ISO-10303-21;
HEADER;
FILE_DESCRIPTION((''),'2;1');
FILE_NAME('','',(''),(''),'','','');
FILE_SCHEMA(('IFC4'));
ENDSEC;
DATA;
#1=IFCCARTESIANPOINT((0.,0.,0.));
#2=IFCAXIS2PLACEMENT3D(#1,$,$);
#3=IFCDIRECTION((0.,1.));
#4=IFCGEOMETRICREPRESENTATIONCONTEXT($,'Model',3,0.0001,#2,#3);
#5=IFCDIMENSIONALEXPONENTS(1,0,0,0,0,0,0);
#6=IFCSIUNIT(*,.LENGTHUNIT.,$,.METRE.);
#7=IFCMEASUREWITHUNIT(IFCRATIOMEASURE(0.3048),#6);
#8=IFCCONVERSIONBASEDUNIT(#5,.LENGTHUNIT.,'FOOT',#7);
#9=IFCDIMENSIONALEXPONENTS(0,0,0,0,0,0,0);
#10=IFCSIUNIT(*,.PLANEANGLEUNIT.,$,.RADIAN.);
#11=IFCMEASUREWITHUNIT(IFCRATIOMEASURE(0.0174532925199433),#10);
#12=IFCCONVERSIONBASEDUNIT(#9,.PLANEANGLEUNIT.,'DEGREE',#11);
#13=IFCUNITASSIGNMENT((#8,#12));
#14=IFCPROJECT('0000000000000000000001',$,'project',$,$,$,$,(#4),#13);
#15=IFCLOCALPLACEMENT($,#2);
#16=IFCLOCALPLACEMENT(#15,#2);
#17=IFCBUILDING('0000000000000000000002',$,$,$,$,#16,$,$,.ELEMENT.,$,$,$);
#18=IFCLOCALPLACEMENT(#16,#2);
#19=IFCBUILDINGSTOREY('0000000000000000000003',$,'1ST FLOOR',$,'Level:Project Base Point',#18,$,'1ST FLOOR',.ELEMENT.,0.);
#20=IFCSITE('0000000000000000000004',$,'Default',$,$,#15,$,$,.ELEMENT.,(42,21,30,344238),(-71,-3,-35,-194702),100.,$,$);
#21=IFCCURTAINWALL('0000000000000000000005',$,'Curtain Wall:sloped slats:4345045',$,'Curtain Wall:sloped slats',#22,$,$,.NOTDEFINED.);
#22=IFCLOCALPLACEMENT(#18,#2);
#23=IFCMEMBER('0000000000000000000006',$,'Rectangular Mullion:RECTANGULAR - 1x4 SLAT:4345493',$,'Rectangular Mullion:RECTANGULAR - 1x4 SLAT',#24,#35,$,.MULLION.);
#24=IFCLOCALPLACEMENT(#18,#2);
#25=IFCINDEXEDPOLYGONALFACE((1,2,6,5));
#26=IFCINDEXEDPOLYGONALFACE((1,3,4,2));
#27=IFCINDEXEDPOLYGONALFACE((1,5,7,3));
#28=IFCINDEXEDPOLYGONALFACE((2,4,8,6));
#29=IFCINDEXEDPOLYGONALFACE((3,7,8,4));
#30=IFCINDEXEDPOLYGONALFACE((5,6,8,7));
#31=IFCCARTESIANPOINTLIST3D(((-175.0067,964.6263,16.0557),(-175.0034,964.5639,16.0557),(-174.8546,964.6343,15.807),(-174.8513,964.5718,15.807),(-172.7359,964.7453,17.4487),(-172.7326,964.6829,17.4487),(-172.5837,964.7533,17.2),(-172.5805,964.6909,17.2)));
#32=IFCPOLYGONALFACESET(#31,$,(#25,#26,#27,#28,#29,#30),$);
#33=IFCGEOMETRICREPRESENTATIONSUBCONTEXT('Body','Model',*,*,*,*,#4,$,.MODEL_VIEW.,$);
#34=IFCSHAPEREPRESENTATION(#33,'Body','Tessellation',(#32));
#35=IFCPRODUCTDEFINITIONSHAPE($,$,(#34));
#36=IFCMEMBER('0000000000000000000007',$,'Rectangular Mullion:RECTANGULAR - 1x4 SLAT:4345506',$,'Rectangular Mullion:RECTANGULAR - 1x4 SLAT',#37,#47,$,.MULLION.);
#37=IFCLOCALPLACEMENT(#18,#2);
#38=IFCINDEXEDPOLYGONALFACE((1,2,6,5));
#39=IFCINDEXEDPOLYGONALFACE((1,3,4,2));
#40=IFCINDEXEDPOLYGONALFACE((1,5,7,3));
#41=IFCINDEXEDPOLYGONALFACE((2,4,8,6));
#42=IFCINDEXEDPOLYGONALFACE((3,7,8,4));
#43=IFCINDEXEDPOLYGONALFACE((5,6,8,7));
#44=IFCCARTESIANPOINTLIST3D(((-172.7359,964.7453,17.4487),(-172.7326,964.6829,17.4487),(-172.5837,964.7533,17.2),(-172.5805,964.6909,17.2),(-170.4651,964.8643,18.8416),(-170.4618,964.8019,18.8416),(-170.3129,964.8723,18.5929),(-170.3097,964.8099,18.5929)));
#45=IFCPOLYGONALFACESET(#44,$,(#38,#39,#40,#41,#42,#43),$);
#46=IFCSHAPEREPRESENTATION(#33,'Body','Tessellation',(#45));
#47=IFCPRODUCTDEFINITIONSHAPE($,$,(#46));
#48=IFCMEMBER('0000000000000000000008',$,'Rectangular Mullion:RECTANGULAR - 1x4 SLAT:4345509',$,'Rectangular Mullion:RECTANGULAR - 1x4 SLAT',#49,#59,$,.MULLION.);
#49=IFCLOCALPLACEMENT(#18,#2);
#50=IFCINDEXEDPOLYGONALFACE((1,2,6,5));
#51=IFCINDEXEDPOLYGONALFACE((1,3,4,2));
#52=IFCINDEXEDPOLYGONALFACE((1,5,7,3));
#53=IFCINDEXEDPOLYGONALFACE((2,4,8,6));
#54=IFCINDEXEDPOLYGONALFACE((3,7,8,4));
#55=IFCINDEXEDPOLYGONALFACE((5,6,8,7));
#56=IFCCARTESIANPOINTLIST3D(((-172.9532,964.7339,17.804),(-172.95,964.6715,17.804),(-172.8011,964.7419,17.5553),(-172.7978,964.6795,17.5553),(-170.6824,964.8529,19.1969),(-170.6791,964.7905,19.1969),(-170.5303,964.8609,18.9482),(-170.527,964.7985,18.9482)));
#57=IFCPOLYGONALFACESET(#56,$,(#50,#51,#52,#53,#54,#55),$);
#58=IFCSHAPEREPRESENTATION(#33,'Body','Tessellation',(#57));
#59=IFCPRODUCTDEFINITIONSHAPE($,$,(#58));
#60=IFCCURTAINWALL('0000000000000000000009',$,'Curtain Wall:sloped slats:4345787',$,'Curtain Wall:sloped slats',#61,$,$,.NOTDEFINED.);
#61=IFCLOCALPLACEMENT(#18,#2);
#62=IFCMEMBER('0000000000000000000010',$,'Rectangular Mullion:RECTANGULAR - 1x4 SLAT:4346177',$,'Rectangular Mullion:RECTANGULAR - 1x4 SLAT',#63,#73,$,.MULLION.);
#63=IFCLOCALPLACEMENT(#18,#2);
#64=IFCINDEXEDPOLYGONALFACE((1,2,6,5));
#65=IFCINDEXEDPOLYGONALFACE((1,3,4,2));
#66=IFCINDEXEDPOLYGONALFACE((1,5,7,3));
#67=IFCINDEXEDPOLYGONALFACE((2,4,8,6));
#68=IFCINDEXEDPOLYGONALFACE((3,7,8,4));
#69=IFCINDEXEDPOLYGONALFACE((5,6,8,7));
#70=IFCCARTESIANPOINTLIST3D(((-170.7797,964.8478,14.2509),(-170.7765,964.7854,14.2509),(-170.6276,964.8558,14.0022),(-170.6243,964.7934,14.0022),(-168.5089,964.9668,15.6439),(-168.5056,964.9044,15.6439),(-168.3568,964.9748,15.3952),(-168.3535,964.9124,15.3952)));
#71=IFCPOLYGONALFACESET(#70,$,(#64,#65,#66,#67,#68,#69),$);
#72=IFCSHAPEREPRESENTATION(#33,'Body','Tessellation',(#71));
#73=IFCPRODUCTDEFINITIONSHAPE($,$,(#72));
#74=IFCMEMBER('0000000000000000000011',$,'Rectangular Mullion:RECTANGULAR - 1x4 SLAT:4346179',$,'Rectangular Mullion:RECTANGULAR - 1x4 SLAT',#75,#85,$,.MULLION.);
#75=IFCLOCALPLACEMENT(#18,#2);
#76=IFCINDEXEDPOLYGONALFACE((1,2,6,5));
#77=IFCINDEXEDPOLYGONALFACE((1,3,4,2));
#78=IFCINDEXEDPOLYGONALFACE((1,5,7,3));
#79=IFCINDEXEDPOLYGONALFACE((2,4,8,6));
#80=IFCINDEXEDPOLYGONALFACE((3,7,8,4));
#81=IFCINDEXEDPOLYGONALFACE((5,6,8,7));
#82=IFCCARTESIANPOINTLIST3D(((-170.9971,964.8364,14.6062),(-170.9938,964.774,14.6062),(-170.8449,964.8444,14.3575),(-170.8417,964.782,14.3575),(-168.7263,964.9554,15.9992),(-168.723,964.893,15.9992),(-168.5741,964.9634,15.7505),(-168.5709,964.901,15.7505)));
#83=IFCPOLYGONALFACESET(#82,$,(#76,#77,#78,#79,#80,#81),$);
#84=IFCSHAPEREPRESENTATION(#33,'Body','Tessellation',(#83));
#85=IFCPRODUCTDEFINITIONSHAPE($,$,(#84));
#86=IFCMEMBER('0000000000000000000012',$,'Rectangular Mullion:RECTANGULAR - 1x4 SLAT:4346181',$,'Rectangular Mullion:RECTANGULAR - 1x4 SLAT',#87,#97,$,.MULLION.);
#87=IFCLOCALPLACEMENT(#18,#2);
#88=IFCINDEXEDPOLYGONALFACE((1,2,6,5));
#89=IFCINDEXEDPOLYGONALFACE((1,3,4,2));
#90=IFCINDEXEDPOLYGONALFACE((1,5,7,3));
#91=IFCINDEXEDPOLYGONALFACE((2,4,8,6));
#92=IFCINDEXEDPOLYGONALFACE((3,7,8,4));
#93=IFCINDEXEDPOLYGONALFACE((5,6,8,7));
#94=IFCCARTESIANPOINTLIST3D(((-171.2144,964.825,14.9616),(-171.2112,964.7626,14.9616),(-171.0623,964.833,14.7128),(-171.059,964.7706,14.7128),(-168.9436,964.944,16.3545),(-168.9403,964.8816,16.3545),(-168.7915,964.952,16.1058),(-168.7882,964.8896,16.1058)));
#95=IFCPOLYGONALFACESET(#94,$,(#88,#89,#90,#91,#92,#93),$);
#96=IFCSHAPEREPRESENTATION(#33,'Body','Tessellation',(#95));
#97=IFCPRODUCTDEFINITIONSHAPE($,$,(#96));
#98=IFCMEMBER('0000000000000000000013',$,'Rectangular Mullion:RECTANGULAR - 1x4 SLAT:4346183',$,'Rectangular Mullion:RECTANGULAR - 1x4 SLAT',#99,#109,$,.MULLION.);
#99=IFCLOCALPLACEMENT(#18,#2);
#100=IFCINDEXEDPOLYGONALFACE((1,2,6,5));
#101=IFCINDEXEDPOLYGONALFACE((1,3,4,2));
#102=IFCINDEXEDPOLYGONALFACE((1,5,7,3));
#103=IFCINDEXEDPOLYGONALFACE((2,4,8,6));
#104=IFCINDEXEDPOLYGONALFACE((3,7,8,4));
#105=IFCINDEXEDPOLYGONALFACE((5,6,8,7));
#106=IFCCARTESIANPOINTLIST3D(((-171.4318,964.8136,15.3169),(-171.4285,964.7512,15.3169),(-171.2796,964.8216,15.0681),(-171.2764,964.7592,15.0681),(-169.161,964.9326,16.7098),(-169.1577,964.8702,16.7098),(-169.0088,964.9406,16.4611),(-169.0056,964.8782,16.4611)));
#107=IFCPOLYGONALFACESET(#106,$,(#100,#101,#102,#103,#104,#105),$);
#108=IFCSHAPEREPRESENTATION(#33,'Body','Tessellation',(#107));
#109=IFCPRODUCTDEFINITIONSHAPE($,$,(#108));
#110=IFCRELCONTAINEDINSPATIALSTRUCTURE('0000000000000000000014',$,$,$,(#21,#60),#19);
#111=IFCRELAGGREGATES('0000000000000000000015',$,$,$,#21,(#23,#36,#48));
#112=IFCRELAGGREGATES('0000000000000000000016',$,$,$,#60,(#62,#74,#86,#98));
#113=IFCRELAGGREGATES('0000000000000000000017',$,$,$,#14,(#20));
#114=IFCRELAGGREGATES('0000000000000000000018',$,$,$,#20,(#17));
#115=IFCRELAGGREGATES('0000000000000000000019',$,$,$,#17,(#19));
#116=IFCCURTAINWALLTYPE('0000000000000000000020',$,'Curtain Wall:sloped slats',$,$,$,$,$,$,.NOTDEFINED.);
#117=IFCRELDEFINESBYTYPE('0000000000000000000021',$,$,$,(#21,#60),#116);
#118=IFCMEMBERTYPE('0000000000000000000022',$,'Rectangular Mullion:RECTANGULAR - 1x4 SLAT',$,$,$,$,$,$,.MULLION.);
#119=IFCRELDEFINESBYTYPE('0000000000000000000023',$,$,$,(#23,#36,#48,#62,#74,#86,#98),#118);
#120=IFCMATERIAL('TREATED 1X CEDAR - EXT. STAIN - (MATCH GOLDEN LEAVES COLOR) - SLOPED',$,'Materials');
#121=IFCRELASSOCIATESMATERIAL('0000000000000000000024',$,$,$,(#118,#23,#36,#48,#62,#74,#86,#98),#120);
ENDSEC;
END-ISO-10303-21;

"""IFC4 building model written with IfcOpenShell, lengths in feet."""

from ifc_helpers import new_model, entity, si_unit, converted_unit, direction, frame, frame_2d, origin, place, context, subcontext, project, spatial, rectangle, extrude, source, transform, mapped, material, material_profile, profile_set, profile_usage, type_object, type_shapes, element, aggregate, save


model = new_model("IFC4")

# Units and contexts
model_context = context("Model", 3, precision=0.0001, world=origin(), true_north=direction((0.0, 1.0)))
body_context = subcontext(model_context, "Body", "Model", "MODEL_VIEW")
ifc_project = project(units=[converted_unit("LENGTHUNIT", "FOOT", entity("IfcRatioMeasure", 0.3048), si_unit("LENGTHUNIT", "METRE"), dimensions=[1, 0, 0, 0, 0, 0, 0]), converted_unit("PLANEANGLEUNIT", "DEGREE", entity("IfcRatioMeasure", 0.0174532925199433), si_unit("PLANEANGLEUNIT", "RADIAN"), dimensions=[0, 0, 0, 0, 0, 0, 0])], contexts=[model_context])

# Site, building, storey
site_placement = place(None, origin())
site = spatial("IfcSite", under=ifc_project, at=site_placement, Name="Default", CompositionType="ELEMENT", RefLatitude=(42, 21, 30, 344238), RefLongitude=(-71, -3, -35, -194702), RefElevation=100.0)
building_placement = place(site_placement, origin())
building = spatial("IfcBuilding", under=site, at=building_placement, CompositionType="ELEMENT")
storey_placement = place(building_placement, origin())
storey = spatial("IfcBuildingStorey", under=building, at=storey_placement, Name="1ST FLOOR", ObjectType="Level:Project Base Point", LongName="1ST FLOOR", CompositionType="ELEMENT", Elevation=0.0)

# Curtain walls, members
curtain_wall_type_1 = type_object("IfcCurtainWallType", Name="Curtain Wall:sloped slats", PredefinedType="NOTDEFINED")
curtain_wall_1_placement = place(storey_placement, origin())
curtain_wall_1 = element("IfcCurtainWall", 1, at=curtain_wall_1_placement, inside=storey, type_object=curtain_wall_type_1, Name="Curtain Wall:sloped slats:4345045", ObjectType="Curtain Wall:sloped slats", PredefinedType="NOTDEFINED")
ifc_material_1 = material(Name="TREATED 1X CEDAR - EXT. STAIN - (MATCH GOLDEN LEAVES COLOR) - SLOPED", Category="Materials")
ifc_material_profile_1 = material_profile(ifc_material_1, rectangle(XDim=0.0625, YDim=0.2917, at=frame_2d((0.0, 0.0), x_axis=(1.0, 0.0))), Name="RECTANGULAR - 1x4 SLAT")
ifc_profile_set_1 = profile_set([ifc_material_profile_1], Name="RECTANGULAR - 1x4 SLAT")
ifc_profile_usage_1 = profile_usage(ifc_profile_set_1)
member_type_1 = type_object("IfcMemberType", Name="Rectangular Mullion:RECTANGULAR - 1x4 SLAT", PredefinedType="MULLION", material=ifc_profile_set_1)
shared_shape_1 = source(origin(), body_context, "Body", "SweptSolid", [
    extrude(rectangle(XDim=0.0625, YDim=0.2917, at=frame_2d((0.0, 0.0), x_axis=(1.0, 0.0))), frame((0.0, 0.0, -2.6667), z_axis=(0.0, 0.0, 1.0), x_axis=(0.0, -1.0, 0.0)), (0.0, 0.0, 1.0), 2.6667),
])
type_shapes(member_type_1, [shared_shape_1])
member_1_placement = place(storey_placement, frame((-174.929, 964.5991, 15.9314), z_axis=(-0.851559, -0.044628, -0.522356), x_axis=(-0.52164, -0.027338, 0.852727)))
member_1 = element("IfcMember", 2, at=member_1_placement, type_object=member_type_1, material=ifc_profile_usage_1, Name="Rectangular Mullion:RECTANGULAR - 1x4 SLAT:4345493", ObjectType="Rectangular Mullion:RECTANGULAR - 1x4 SLAT", PredefinedType="MULLION", context=body_context, shape_type="MappedRepresentation", body=[
    mapped(shared_shape_1, transform((0.0, 0.0, 0.0), scale=1.0)),
])
ifc_profile_usage_2 = profile_usage(ifc_profile_set_1)
member_2_placement = place(storey_placement, frame((-172.6582, 964.7181, 17.3243), z_axis=(-0.851559, -0.044628, -0.522356), x_axis=(-0.52164, -0.027338, 0.852727)))
member_2 = element("IfcMember", 3, at=member_2_placement, type_object=member_type_1, material=ifc_profile_usage_2, Name="Rectangular Mullion:RECTANGULAR - 1x4 SLAT:4345506", ObjectType="Rectangular Mullion:RECTANGULAR - 1x4 SLAT", PredefinedType="MULLION", context=body_context, shape_type="MappedRepresentation", body=[
    mapped(shared_shape_1, transform((0.0, 0.0, 0.0), scale=1.0)),
])
ifc_profile_usage_3 = profile_usage(ifc_profile_set_1)
member_3_placement = place(storey_placement, frame((-172.8755, 964.7067, 17.6796), z_axis=(-0.851559, -0.044628, -0.522356), x_axis=(-0.52164, -0.027338, 0.852727)))
member_3 = element("IfcMember", 4, at=member_3_placement, type_object=member_type_1, material=ifc_profile_usage_3, Name="Rectangular Mullion:RECTANGULAR - 1x4 SLAT:4345509", ObjectType="Rectangular Mullion:RECTANGULAR - 1x4 SLAT", PredefinedType="MULLION", context=body_context, shape_type="MappedRepresentation", body=[
    mapped(shared_shape_1, transform((0.0, 0.0, 0.0), scale=1.0)),
])
aggregate(curtain_wall_1, [member_1, member_2, member_3])
curtain_wall_2_placement = place(storey_placement, origin())
curtain_wall_2 = element("IfcCurtainWall", 5, at=curtain_wall_2_placement, inside=storey, type_object=curtain_wall_type_1, Name="Curtain Wall:sloped slats:4345787", ObjectType="Curtain Wall:sloped slats", PredefinedType="NOTDEFINED")
ifc_profile_usage_4 = profile_usage(ifc_profile_set_1)
member_4_placement = place(storey_placement, frame((-170.702, 964.8206, 14.1266), z_axis=(-0.851559, -0.044628, -0.522356), x_axis=(-0.52164, -0.027338, 0.852727)))
member_4 = element("IfcMember", 6, at=member_4_placement, type_object=member_type_1, material=ifc_profile_usage_4, Name="Rectangular Mullion:RECTANGULAR - 1x4 SLAT:4346177", ObjectType="Rectangular Mullion:RECTANGULAR - 1x4 SLAT", PredefinedType="MULLION", context=body_context, shape_type="MappedRepresentation", body=[
    mapped(shared_shape_1, transform((0.0, 0.0, 0.0), scale=1.0)),
])
ifc_profile_usage_5 = profile_usage(ifc_profile_set_1)
member_5_placement = place(storey_placement, frame((-170.9194, 964.8092, 14.4819), z_axis=(-0.851559, -0.044628, -0.522356), x_axis=(-0.52164, -0.027338, 0.852727)))
member_5 = element("IfcMember", 7, at=member_5_placement, type_object=member_type_1, material=ifc_profile_usage_5, Name="Rectangular Mullion:RECTANGULAR - 1x4 SLAT:4346179", ObjectType="Rectangular Mullion:RECTANGULAR - 1x4 SLAT", PredefinedType="MULLION", context=body_context, shape_type="MappedRepresentation", body=[
    mapped(shared_shape_1, transform((0.0, 0.0, 0.0), scale=1.0)),
])
ifc_profile_usage_6 = profile_usage(ifc_profile_set_1)
member_6_placement = place(storey_placement, frame((-171.1367, 964.7978, 14.8372), z_axis=(-0.851559, -0.044628, -0.522356), x_axis=(-0.52164, -0.027338, 0.852727)))
member_6 = element("IfcMember", 8, at=member_6_placement, type_object=member_type_1, material=ifc_profile_usage_6, Name="Rectangular Mullion:RECTANGULAR - 1x4 SLAT:4346181", ObjectType="Rectangular Mullion:RECTANGULAR - 1x4 SLAT", PredefinedType="MULLION", context=body_context, shape_type="MappedRepresentation", body=[
    mapped(shared_shape_1, transform((0.0, 0.0, 0.0), scale=1.0)),
])
ifc_profile_usage_7 = profile_usage(ifc_profile_set_1)
member_7_placement = place(storey_placement, frame((-171.3541, 964.7864, 15.1925), z_axis=(-0.851559, -0.044628, -0.522356), x_axis=(-0.52164, -0.027338, 0.852727)))
member_7 = element("IfcMember", 9, at=member_7_placement, type_object=member_type_1, material=ifc_profile_usage_7, Name="Rectangular Mullion:RECTANGULAR - 1x4 SLAT:4346183", ObjectType="Rectangular Mullion:RECTANGULAR - 1x4 SLAT", PredefinedType="MULLION", context=body_context, shape_type="MappedRepresentation", body=[
    mapped(shared_shape_1, transform((0.0, 0.0, 0.0), scale=1.0)),
])
aggregate(curtain_wall_2, [member_4, member_5, member_6, member_7])

save(model, "model.ifc")
